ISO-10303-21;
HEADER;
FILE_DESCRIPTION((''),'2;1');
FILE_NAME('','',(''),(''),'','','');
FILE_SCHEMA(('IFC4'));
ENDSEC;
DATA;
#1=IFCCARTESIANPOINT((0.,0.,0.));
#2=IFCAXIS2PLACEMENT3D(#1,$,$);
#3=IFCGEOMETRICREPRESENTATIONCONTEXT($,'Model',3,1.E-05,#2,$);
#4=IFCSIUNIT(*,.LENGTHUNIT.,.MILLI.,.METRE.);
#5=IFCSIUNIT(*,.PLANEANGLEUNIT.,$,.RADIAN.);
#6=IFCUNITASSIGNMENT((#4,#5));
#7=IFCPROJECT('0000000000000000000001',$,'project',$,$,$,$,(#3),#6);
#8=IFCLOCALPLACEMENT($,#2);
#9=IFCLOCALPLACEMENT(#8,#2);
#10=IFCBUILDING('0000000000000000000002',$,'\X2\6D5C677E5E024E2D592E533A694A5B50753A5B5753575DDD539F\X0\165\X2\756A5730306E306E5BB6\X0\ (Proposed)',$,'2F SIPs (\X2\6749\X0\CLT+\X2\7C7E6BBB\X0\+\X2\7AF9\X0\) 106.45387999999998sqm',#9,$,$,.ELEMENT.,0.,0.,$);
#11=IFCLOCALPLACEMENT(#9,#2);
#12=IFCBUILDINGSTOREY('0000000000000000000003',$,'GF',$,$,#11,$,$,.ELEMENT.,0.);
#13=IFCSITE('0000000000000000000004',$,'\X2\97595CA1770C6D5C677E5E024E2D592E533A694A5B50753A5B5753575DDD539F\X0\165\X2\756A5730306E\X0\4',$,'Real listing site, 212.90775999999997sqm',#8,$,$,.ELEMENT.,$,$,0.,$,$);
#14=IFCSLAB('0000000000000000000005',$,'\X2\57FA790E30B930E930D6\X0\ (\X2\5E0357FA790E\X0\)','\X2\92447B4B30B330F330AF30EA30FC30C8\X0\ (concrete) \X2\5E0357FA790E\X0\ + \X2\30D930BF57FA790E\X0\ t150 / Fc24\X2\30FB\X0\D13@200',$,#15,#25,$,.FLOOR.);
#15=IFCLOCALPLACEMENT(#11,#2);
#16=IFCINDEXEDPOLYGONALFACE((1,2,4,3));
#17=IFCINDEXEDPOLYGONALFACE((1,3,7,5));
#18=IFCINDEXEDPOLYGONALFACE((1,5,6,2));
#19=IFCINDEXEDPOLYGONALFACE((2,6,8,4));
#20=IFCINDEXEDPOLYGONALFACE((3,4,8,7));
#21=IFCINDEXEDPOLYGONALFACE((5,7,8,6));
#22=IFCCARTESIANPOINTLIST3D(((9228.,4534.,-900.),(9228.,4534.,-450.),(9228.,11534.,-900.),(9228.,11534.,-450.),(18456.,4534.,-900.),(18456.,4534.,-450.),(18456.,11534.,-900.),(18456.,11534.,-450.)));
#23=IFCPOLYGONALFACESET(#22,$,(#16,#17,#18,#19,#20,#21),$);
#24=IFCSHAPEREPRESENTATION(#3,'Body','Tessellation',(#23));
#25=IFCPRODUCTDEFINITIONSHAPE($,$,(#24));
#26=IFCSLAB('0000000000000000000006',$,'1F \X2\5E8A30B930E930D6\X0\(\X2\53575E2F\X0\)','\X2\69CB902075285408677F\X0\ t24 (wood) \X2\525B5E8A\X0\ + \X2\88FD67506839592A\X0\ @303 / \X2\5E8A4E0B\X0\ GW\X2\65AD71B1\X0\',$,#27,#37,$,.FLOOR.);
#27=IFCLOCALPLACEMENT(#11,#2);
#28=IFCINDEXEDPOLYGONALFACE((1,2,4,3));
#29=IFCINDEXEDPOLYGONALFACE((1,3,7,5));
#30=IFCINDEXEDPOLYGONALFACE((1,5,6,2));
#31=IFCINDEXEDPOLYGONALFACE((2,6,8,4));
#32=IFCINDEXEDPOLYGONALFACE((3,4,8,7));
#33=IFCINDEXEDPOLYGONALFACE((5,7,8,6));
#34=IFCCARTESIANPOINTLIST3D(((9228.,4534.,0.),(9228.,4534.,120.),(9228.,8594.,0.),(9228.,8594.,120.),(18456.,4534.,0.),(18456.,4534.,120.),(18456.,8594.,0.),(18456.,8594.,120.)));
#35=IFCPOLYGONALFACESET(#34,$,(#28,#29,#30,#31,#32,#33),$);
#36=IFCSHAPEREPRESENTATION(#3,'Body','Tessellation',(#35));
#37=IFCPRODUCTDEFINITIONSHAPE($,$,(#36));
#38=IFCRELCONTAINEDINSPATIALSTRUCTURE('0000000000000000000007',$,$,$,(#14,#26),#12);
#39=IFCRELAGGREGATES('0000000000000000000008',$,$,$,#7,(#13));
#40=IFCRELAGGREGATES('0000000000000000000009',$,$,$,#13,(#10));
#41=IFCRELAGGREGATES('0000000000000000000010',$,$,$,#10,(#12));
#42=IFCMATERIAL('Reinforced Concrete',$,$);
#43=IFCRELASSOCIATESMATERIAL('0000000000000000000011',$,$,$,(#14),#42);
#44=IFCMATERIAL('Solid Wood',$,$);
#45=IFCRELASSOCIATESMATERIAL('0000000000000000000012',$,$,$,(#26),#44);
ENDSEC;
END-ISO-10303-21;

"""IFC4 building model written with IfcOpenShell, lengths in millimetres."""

from ifc_helpers import new_model, si_unit, frame, frame_2d, origin, place, context, project, spatial, rectangle, extrude, material, element, save


model = new_model("IFC4")

# Units and contexts
model_context = context("Model", 3, precision=1e-05, world=origin())
ifc_project = project(units=[si_unit("LENGTHUNIT", "METRE", prefix="MILLI"), si_unit("PLANEANGLEUNIT", "RADIAN")], contexts=[model_context])

# Site, building, storey
site_placement = place(None, origin())
site = spatial("IfcSite", under=ifc_project, at=site_placement, Name="静岡県浜松市中央区楊子町字南川原165番地の4", ObjectType="Real listing site, 212.90775999999997sqm", CompositionType="ELEMENT", RefElevation=0.0)
building_placement = place(site_placement, origin())
building = spatial("IfcBuilding", under=site, at=building_placement, Name="浜松市中央区楊子町字南川原165番地のの家 (Proposed)", ObjectType="2F SIPs (杉CLT+籾殻+竹) 106.45387999999998sqm", CompositionType="ELEMENT", ElevationOfRefHeight=0.0, ElevationOfTerrain=0.0)
storey_placement = place(building_placement, origin())
storey = spatial("IfcBuildingStorey", under=building, at=storey_placement, Name="GF", CompositionType="ELEMENT", Elevation=0.0)

# Slabs
ifc_material_1 = material(Name="Reinforced Concrete")
slab_1_placement = place(storey_placement, frame((4614.0, 2267.0, -450.0)))
element("IfcSlab", 1, at=slab_1_placement, inside=storey, material=ifc_material_1, Name="基礎スラブ (布基礎)", Description="鉄筋コンクリート (concrete) 布基礎 + ベタ基礎 t150 / Fc24・D13@200", PredefinedType="FLOOR", context=model_context, shape_type="SweptSolid", body=[
    extrude(rectangle(XDim=9228.0, YDim=7000.0, at=frame_2d((4614.0, 3500.0))), frame((4614.0, 2267.0, -450.0)), (0.0, 0.0, 1.0), 450.0),
])
ifc_material_2 = material(Name="Solid Wood")
slab_2_placement = place(storey_placement, frame((4614.0, 2267.0, 0.0)))
element("IfcSlab", 2, at=slab_2_placement, inside=storey, material=ifc_material_2, Name="1F 床スラブ(南帯)", Description="構造用合板 t24 (wood) 剛床 + 製材根太 @303 / 床下 GW断熱", PredefinedType="FLOOR", context=model_context, shape_type="SweptSolid", body=[
    extrude(rectangle(XDim=9228.0, YDim=4060.0, at=frame_2d((4614.0, 2030.0))), frame((4614.0, 2267.0, 0.0)), (0.0, 0.0, 1.0), 120.0),
])

save(model, "model.ifc")
